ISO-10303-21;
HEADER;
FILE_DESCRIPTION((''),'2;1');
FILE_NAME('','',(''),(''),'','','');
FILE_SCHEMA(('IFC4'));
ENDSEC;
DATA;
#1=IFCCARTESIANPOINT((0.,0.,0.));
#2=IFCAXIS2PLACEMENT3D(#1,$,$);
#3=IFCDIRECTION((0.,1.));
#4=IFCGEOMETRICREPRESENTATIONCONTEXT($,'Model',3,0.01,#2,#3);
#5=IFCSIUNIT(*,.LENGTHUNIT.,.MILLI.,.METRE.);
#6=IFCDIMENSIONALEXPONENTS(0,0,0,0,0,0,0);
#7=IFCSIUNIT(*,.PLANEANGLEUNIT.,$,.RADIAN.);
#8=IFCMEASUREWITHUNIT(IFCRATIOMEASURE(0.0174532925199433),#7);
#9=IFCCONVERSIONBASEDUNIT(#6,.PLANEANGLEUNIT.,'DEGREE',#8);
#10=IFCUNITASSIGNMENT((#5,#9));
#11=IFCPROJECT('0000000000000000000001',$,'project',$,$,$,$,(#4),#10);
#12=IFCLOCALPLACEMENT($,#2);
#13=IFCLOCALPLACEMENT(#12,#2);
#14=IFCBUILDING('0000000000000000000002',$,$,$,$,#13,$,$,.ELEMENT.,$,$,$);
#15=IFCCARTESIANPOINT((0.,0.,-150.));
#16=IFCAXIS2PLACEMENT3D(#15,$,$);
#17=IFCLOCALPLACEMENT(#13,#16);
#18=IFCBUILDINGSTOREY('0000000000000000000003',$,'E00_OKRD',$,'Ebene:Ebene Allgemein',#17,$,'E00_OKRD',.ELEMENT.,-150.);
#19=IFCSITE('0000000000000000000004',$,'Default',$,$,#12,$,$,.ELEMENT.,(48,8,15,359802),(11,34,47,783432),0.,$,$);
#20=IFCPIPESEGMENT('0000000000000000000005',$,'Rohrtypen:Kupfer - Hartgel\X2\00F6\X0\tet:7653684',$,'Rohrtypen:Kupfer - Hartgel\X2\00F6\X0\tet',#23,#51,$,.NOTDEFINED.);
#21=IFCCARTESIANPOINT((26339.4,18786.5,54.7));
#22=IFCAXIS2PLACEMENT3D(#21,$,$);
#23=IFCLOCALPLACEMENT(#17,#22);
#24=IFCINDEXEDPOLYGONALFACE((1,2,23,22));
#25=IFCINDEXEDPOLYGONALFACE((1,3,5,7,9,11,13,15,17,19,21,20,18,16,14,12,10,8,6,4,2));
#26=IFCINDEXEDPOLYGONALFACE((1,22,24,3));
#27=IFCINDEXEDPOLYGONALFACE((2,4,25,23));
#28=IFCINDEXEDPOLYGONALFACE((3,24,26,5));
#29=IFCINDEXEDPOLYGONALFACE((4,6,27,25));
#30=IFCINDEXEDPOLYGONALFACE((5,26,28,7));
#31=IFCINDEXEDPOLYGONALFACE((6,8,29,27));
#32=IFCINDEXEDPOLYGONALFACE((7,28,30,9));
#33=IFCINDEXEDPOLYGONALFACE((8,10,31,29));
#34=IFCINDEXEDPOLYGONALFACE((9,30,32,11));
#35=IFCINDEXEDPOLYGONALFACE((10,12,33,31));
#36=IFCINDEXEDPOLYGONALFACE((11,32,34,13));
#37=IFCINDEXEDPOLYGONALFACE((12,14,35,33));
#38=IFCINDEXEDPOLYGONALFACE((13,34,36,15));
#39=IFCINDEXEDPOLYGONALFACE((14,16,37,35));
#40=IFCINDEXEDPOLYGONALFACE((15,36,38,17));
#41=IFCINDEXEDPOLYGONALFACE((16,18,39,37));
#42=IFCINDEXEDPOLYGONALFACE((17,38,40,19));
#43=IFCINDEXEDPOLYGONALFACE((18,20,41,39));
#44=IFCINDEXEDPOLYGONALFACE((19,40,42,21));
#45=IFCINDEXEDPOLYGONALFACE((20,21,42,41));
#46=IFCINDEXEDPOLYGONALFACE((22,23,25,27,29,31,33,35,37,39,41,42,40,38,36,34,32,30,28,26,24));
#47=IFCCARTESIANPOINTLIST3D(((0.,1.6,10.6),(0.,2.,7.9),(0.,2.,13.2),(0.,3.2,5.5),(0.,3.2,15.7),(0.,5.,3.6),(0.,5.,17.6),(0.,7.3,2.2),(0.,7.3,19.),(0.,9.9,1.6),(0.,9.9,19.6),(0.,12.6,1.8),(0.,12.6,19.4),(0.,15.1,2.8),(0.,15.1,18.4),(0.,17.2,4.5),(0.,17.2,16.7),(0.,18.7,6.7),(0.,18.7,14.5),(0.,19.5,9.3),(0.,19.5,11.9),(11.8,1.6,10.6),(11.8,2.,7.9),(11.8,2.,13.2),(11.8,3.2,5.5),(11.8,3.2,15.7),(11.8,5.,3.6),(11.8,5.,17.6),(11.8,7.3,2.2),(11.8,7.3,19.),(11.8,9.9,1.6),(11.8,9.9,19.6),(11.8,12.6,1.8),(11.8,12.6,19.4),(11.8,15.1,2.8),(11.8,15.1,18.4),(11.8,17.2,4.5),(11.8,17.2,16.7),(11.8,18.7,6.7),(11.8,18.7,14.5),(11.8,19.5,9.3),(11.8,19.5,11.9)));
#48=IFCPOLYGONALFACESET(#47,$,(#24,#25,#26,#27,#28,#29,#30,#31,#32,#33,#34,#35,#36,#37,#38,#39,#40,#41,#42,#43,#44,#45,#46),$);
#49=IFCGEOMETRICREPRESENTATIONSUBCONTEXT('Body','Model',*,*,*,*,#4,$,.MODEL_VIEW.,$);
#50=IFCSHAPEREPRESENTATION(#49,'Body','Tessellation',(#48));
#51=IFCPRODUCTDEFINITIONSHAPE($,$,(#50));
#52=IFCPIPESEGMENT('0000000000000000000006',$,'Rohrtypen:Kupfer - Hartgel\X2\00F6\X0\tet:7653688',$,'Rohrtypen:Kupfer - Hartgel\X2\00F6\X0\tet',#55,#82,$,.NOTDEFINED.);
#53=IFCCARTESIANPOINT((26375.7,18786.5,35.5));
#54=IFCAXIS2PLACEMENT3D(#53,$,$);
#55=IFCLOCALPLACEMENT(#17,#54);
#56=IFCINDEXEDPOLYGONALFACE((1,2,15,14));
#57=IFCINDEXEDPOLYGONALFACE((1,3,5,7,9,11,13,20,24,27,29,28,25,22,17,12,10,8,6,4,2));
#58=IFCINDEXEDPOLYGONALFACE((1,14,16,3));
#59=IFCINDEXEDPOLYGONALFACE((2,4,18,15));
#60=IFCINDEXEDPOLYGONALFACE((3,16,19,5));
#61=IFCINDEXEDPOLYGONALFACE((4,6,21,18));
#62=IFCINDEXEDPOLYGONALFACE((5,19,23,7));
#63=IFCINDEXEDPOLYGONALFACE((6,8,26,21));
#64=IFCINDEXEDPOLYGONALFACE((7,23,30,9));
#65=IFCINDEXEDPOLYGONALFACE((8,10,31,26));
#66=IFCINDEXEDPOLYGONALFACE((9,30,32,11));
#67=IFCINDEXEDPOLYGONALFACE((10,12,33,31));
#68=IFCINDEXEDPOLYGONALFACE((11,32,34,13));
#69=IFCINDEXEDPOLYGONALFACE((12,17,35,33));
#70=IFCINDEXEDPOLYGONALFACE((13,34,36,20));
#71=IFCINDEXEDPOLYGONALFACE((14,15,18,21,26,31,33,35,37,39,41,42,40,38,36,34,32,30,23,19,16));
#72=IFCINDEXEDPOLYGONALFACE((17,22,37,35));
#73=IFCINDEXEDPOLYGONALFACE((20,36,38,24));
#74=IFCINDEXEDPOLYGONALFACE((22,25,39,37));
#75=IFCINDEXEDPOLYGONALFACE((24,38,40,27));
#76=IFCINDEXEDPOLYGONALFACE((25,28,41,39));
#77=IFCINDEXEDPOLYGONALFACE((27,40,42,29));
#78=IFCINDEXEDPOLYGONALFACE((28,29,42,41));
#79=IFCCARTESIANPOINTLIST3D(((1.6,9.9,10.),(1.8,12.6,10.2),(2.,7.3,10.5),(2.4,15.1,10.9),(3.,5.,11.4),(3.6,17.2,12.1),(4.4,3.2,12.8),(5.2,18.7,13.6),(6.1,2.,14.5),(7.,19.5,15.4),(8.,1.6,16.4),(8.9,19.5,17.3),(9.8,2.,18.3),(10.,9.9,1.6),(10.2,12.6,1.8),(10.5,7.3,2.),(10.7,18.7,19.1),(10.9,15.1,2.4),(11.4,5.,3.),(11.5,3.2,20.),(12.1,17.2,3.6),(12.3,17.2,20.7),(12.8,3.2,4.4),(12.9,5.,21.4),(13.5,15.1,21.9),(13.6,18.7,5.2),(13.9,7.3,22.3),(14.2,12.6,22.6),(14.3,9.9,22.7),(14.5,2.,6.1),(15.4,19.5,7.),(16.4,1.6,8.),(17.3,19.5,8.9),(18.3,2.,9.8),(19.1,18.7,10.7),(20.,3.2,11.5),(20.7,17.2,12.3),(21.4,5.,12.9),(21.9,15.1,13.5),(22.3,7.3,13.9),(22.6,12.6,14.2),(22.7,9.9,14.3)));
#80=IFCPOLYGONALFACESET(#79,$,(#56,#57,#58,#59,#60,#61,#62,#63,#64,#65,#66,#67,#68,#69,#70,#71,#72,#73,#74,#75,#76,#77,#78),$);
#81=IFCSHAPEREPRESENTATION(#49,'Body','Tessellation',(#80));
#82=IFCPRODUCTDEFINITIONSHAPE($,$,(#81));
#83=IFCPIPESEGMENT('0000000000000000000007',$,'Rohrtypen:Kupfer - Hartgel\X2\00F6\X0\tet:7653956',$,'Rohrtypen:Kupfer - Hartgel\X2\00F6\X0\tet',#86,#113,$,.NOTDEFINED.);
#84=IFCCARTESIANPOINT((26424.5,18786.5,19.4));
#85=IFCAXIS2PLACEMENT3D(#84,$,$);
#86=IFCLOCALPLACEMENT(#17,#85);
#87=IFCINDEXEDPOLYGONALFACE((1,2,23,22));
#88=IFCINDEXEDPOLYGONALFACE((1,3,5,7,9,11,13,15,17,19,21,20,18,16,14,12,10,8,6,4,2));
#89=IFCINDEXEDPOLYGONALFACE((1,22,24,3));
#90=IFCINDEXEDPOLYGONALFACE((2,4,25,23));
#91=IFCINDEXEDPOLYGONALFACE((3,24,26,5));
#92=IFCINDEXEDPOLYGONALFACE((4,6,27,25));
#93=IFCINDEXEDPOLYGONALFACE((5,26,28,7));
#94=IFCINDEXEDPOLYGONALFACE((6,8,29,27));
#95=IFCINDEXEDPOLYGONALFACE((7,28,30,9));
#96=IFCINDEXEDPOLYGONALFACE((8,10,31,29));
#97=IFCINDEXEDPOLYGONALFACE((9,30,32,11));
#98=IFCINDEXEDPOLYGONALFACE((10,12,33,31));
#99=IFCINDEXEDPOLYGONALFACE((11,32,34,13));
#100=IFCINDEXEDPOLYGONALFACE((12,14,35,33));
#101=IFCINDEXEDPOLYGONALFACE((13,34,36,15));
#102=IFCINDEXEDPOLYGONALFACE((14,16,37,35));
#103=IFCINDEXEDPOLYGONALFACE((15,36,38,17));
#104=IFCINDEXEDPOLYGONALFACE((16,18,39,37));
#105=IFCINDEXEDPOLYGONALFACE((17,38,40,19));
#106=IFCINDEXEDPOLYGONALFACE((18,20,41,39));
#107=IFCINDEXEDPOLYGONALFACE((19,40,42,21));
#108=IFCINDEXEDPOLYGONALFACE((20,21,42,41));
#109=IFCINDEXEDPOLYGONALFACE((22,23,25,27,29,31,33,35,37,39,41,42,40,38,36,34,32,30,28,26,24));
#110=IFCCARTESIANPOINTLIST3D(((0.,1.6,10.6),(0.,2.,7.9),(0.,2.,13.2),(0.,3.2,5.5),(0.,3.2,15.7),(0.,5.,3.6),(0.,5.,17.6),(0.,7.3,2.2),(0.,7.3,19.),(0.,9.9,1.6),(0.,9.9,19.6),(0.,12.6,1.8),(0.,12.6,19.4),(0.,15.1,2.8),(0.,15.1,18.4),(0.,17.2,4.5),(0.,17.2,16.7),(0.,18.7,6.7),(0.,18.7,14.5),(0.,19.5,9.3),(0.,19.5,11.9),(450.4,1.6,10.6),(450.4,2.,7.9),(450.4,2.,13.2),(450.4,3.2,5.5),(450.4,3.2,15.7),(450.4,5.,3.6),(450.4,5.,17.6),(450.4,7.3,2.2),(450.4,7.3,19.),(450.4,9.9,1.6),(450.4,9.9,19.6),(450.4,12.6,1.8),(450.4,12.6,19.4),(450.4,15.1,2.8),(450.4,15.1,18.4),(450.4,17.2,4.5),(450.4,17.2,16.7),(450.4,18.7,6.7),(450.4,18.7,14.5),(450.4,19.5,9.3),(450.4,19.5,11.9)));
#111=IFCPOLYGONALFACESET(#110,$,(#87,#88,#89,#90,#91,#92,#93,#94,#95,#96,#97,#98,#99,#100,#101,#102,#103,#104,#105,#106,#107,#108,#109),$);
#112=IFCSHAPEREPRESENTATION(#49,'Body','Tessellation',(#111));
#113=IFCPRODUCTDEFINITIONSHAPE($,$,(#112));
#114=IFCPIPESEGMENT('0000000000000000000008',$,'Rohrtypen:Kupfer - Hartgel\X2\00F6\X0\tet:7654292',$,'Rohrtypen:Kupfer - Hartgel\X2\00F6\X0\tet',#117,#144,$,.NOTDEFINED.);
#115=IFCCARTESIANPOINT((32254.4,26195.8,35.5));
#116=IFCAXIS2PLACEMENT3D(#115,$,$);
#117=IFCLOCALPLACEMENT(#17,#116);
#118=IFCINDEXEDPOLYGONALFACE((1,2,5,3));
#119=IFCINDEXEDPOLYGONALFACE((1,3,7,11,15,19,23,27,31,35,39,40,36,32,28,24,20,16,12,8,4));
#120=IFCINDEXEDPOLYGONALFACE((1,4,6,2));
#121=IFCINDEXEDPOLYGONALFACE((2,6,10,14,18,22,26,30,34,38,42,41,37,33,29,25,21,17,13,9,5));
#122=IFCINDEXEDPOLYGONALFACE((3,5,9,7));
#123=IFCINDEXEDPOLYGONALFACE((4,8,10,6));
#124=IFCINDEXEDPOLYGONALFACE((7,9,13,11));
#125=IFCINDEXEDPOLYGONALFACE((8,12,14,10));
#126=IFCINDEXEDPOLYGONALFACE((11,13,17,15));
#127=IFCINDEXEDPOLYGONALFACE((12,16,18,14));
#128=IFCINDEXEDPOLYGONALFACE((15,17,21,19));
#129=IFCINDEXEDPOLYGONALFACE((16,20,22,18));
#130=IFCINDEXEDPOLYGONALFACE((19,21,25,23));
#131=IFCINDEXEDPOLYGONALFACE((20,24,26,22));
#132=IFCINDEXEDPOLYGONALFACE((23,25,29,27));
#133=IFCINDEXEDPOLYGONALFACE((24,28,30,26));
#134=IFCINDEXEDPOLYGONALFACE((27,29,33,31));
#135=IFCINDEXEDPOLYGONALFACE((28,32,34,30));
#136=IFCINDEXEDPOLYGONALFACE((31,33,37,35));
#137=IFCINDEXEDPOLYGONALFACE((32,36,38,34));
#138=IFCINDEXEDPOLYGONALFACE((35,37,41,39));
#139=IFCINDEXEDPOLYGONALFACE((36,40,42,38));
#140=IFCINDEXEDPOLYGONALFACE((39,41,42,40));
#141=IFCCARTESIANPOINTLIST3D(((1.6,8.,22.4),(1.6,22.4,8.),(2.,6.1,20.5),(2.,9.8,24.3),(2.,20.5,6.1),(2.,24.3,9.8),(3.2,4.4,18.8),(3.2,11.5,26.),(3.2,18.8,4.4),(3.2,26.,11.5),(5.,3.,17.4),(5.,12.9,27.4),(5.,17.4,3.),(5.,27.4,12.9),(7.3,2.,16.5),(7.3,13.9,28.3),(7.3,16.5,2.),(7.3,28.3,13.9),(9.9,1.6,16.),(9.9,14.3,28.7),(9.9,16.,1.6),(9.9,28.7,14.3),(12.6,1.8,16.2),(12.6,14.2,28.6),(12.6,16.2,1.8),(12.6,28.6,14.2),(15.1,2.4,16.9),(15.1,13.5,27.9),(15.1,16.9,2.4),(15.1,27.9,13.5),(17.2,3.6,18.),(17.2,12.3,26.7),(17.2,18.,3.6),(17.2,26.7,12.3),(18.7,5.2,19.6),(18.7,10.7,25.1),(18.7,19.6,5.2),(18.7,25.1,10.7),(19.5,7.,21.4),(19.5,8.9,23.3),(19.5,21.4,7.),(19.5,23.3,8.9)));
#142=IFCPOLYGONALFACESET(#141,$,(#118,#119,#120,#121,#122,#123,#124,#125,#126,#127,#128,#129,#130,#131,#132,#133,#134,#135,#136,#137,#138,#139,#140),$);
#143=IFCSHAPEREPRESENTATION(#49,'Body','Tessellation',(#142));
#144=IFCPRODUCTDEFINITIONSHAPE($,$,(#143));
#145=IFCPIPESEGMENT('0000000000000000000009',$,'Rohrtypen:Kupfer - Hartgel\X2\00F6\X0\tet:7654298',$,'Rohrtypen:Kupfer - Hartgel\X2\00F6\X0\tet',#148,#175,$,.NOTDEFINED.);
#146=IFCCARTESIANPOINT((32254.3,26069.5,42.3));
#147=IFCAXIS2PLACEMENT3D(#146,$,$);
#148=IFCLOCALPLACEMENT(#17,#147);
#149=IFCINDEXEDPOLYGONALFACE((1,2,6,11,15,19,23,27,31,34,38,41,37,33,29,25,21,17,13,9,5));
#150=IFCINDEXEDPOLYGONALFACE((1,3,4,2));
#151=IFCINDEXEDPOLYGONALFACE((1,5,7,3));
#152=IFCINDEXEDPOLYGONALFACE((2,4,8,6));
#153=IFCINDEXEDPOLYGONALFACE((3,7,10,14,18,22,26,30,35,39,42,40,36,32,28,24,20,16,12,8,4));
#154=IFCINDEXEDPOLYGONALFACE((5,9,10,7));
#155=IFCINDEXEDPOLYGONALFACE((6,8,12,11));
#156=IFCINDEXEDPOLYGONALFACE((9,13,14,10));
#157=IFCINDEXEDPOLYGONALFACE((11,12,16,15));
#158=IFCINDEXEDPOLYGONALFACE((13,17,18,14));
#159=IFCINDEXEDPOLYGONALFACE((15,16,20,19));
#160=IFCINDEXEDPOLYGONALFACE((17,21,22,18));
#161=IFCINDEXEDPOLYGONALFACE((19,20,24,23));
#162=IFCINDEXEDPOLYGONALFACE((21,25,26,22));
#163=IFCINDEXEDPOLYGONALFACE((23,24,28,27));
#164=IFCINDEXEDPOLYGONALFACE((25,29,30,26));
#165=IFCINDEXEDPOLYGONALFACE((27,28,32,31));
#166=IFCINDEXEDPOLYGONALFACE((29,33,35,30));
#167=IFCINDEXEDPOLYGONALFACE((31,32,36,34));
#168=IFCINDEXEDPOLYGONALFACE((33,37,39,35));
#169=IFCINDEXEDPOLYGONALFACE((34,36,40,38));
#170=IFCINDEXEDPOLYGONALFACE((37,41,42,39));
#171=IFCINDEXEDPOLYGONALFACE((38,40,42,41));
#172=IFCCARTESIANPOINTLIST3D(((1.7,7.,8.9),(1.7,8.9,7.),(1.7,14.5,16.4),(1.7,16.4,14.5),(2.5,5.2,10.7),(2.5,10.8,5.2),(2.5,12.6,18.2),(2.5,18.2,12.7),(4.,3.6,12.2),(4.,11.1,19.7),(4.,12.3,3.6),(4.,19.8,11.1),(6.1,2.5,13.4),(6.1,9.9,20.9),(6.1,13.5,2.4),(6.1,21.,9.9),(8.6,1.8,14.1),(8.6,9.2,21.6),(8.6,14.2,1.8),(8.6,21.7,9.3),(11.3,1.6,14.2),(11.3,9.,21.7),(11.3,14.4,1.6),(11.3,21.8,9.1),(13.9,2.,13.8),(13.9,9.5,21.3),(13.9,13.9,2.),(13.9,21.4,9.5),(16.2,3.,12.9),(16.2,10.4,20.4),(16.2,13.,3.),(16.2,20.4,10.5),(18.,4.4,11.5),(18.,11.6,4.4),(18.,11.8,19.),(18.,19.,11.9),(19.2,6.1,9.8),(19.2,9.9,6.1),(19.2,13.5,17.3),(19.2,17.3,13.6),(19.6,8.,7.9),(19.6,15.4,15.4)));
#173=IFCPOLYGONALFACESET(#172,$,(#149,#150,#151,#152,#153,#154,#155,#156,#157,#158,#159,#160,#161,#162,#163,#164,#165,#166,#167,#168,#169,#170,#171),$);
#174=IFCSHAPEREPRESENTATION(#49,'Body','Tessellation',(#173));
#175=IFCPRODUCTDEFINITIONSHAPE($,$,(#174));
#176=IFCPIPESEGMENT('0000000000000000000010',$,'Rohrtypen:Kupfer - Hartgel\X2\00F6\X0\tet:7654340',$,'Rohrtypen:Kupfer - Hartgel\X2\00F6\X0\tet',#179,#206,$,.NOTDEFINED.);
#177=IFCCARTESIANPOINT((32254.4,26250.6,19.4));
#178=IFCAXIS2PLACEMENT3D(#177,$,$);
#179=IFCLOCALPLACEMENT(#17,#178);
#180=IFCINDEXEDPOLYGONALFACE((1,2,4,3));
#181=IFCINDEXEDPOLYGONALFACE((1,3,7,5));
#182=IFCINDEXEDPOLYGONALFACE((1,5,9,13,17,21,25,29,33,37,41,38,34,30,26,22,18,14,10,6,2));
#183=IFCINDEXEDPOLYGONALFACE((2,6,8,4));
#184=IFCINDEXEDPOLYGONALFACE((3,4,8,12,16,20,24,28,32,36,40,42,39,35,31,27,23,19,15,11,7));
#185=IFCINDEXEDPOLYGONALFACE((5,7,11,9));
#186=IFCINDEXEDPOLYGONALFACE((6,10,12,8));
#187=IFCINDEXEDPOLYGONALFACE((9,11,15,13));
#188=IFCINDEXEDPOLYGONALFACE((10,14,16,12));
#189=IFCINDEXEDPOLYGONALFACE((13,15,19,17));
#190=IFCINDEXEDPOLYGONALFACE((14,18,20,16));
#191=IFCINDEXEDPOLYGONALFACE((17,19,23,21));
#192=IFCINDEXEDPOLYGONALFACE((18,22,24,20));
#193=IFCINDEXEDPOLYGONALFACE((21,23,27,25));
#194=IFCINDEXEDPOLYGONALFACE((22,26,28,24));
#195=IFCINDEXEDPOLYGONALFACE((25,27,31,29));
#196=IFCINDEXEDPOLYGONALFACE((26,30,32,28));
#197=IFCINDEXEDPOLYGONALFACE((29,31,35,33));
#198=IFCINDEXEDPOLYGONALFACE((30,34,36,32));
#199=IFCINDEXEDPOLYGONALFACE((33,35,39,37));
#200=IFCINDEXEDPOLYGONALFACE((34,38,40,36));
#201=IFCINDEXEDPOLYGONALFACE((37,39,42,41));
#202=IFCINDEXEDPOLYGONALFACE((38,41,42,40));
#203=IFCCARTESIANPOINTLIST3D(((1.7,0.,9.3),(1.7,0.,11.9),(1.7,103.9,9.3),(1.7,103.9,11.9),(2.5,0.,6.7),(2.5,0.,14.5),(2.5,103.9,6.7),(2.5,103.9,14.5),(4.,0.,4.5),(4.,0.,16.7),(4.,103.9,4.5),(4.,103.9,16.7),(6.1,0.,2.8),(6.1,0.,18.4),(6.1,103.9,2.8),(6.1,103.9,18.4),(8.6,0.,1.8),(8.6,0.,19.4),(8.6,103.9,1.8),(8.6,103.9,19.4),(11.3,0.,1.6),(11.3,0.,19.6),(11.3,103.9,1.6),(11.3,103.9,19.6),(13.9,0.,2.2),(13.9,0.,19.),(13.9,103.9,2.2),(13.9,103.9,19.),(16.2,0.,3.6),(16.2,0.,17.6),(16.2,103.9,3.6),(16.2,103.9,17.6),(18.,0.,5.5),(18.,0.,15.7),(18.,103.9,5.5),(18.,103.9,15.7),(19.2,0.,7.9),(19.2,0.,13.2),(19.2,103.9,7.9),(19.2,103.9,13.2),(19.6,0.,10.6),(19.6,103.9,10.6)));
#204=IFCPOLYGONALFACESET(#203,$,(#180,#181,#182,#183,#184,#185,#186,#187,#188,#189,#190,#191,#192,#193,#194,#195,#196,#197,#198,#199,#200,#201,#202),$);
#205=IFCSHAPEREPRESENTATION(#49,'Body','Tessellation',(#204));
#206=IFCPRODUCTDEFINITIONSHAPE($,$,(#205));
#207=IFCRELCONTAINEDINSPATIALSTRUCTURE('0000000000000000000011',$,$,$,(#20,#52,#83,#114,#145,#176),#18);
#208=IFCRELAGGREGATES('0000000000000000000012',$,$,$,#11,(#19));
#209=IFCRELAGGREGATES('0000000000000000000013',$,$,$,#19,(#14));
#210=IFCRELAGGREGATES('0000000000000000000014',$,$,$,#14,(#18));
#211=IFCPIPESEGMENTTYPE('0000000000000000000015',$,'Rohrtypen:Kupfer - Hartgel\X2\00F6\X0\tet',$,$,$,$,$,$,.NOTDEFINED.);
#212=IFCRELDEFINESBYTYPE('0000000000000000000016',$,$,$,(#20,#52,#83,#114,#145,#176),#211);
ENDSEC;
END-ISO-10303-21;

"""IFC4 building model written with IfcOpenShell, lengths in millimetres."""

from ifc_helpers import new_model, entity, si_unit, converted_unit, direction, frame, frame_2d, origin, origin_2d_with_axis, place, context, subcontext, project, spatial, circle, extrude, type_object, element, save


model = new_model("IFC4")

# Units and contexts
model_context = context("Model", 3, precision=0.01, world=origin(), true_north=direction((0.0, 1.0)))
body_context = subcontext(model_context, "Body", "Model", "MODEL_VIEW")
ifc_project = project(units=[si_unit("LENGTHUNIT", "METRE", prefix="MILLI"), converted_unit("PLANEANGLEUNIT", "DEGREE", entity("IfcRatioMeasure", 0.0174532925199433), si_unit("PLANEANGLEUNIT", "RADIAN"), dimensions=[0, 0, 0, 0, 0, 0, 0])], contexts=[model_context])

# Site, building, storey
site_placement = place(None, origin())
site = spatial("IfcSite", under=ifc_project, at=site_placement, Name="Default", CompositionType="ELEMENT", RefLatitude=(48, 8, 15, 359802), RefLongitude=(11, 34, 47, 783432), RefElevation=0.0)
building_placement = place(site_placement, origin())
building = spatial("IfcBuilding", under=site, at=building_placement, CompositionType="ELEMENT")
storey_placement = place(building_placement, frame((0.0, 0.0, -150.0)))
storey = spatial("IfcBuildingStorey", under=building, at=storey_placement, Name="E00_OKRD", ObjectType="Ebene:Ebene Allgemein", LongName="E00_OKRD", CompositionType="ELEMENT", Elevation=-150.0)

# Pipe segments
pipe_segment_type = type_object("IfcPipeSegmentType", Name="Rohrtypen:Kupfer - Hartgelötet", PredefinedType="NOTDEFINED")
pipe_segment_1_placement = place(storey_placement, frame((26339.4, 18786.5, 54.7)))
element("IfcPipeSegment", 1, at=pipe_segment_1_placement, inside=storey, type_object=pipe_segment_type, Name="Rohrtypen:Kupfer - Hartgelötet:7653684", ObjectType="Rohrtypen:Kupfer - Hartgelötet", PredefinedType="NOTDEFINED", context=body_context, shape_type="SweptSolid", body=[
    extrude(circle(Radius=9.0, at=origin_2d_with_axis()), frame((0.0, 10.6, 10.6), z_axis=(1.0, 0.0, 0.0), x_axis=(0.0, -1.0, 0.0)), (0.0, 0.0, 1.0), 11.8),
])
pipe_segment_2_placement = place(storey_placement, frame((26375.7, 18786.5, 35.5)))
element("IfcPipeSegment", 2, at=pipe_segment_2_placement, inside=storey, type_object=pipe_segment_type, Name="Rohrtypen:Kupfer - Hartgelötet:7653688", ObjectType="Rohrtypen:Kupfer - Hartgelötet", PredefinedType="NOTDEFINED", context=body_context, shape_type="SweptSolid", body=[
    extrude(circle(Radius=9.0, at=origin_2d_with_axis()), frame((16.4, 10.6, 8.0), z_axis=(-0.707107, 0.0, 0.707107), x_axis=(0.0, -1.0, 0.0)), (0.0, 0.0, 1.0), 11.9),
])
pipe_segment_3_placement = place(storey_placement, frame((26424.5, 18786.5, 19.4)))
element("IfcPipeSegment", 3, at=pipe_segment_3_placement, inside=storey, type_object=pipe_segment_type, Name="Rohrtypen:Kupfer - Hartgelötet:7653956", ObjectType="Rohrtypen:Kupfer - Hartgelötet", PredefinedType="NOTDEFINED", context=body_context, shape_type="SweptSolid", body=[
    extrude(circle(Radius=9.0, at=frame_2d((0.0, 0.0), x_axis=(1.0, 0.0))), frame((0.0, 10.6, 10.6), z_axis=(1.0, 0.0, 0.0), x_axis=(0.0, -1.0, 0.0)), (0.0, 0.0, 1.0), 450.4),
])
pipe_segment_4_placement = place(storey_placement, frame((32254.4, 26195.8, 35.5)))
element("IfcPipeSegment", 4, at=pipe_segment_4_placement, inside=storey, type_object=pipe_segment_type, Name="Rohrtypen:Kupfer - Hartgelötet:7654292", ObjectType="Rohrtypen:Kupfer - Hartgelötet", PredefinedType="NOTDEFINED", context=body_context, shape_type="SweptSolid", body=[
    extrude(circle(Radius=9.0, at=origin_2d_with_axis()), frame((10.6, 8.0, 22.4), z_axis=(0.0, 0.707107, -0.707107), x_axis=(-1.0, 0.0, 0.0)), (0.0, 0.0, 1.0), 20.4),
])
pipe_segment_5_placement = place(storey_placement, frame((32254.3, 26069.5, 42.3)))
element("IfcPipeSegment", 5, at=pipe_segment_5_placement, inside=storey, type_object=pipe_segment_type, Name="Rohrtypen:Kupfer - Hartgelötet:7654298", ObjectType="Rohrtypen:Kupfer - Hartgelötet", PredefinedType="NOTDEFINED", context=body_context, shape_type="SweptSolid", body=[
    extrude(circle(Radius=9.0, at=frame_2d((0.0, 0.0), x_axis=(1.0, 0.0))), frame((10.6, 8.0, 7.9), z_axis=(0.0, 0.70394, 0.71026), x_axis=(1.0, 0.0, 0.0)), (0.0, 0.0, 1.0), 10.6),
])
pipe_segment_6_placement = place(storey_placement, frame((32254.4, 26250.6, 19.4)))
element("IfcPipeSegment", 6, at=pipe_segment_6_placement, inside=storey, type_object=pipe_segment_type, Name="Rohrtypen:Kupfer - Hartgelötet:7654340", ObjectType="Rohrtypen:Kupfer - Hartgelötet", PredefinedType="NOTDEFINED", context=body_context, shape_type="SweptSolid", body=[
    extrude(circle(Radius=9.0, at=frame_2d((0.0, 0.0), x_axis=(1.0, 0.0))), frame((10.6, 0.0, 10.6), z_axis=(0.0, 1.0, 0.0), x_axis=(1.0, 0.0, 0.0)), (0.0, 0.0, 1.0), 103.9),
])

save(model, "model.ifc")
